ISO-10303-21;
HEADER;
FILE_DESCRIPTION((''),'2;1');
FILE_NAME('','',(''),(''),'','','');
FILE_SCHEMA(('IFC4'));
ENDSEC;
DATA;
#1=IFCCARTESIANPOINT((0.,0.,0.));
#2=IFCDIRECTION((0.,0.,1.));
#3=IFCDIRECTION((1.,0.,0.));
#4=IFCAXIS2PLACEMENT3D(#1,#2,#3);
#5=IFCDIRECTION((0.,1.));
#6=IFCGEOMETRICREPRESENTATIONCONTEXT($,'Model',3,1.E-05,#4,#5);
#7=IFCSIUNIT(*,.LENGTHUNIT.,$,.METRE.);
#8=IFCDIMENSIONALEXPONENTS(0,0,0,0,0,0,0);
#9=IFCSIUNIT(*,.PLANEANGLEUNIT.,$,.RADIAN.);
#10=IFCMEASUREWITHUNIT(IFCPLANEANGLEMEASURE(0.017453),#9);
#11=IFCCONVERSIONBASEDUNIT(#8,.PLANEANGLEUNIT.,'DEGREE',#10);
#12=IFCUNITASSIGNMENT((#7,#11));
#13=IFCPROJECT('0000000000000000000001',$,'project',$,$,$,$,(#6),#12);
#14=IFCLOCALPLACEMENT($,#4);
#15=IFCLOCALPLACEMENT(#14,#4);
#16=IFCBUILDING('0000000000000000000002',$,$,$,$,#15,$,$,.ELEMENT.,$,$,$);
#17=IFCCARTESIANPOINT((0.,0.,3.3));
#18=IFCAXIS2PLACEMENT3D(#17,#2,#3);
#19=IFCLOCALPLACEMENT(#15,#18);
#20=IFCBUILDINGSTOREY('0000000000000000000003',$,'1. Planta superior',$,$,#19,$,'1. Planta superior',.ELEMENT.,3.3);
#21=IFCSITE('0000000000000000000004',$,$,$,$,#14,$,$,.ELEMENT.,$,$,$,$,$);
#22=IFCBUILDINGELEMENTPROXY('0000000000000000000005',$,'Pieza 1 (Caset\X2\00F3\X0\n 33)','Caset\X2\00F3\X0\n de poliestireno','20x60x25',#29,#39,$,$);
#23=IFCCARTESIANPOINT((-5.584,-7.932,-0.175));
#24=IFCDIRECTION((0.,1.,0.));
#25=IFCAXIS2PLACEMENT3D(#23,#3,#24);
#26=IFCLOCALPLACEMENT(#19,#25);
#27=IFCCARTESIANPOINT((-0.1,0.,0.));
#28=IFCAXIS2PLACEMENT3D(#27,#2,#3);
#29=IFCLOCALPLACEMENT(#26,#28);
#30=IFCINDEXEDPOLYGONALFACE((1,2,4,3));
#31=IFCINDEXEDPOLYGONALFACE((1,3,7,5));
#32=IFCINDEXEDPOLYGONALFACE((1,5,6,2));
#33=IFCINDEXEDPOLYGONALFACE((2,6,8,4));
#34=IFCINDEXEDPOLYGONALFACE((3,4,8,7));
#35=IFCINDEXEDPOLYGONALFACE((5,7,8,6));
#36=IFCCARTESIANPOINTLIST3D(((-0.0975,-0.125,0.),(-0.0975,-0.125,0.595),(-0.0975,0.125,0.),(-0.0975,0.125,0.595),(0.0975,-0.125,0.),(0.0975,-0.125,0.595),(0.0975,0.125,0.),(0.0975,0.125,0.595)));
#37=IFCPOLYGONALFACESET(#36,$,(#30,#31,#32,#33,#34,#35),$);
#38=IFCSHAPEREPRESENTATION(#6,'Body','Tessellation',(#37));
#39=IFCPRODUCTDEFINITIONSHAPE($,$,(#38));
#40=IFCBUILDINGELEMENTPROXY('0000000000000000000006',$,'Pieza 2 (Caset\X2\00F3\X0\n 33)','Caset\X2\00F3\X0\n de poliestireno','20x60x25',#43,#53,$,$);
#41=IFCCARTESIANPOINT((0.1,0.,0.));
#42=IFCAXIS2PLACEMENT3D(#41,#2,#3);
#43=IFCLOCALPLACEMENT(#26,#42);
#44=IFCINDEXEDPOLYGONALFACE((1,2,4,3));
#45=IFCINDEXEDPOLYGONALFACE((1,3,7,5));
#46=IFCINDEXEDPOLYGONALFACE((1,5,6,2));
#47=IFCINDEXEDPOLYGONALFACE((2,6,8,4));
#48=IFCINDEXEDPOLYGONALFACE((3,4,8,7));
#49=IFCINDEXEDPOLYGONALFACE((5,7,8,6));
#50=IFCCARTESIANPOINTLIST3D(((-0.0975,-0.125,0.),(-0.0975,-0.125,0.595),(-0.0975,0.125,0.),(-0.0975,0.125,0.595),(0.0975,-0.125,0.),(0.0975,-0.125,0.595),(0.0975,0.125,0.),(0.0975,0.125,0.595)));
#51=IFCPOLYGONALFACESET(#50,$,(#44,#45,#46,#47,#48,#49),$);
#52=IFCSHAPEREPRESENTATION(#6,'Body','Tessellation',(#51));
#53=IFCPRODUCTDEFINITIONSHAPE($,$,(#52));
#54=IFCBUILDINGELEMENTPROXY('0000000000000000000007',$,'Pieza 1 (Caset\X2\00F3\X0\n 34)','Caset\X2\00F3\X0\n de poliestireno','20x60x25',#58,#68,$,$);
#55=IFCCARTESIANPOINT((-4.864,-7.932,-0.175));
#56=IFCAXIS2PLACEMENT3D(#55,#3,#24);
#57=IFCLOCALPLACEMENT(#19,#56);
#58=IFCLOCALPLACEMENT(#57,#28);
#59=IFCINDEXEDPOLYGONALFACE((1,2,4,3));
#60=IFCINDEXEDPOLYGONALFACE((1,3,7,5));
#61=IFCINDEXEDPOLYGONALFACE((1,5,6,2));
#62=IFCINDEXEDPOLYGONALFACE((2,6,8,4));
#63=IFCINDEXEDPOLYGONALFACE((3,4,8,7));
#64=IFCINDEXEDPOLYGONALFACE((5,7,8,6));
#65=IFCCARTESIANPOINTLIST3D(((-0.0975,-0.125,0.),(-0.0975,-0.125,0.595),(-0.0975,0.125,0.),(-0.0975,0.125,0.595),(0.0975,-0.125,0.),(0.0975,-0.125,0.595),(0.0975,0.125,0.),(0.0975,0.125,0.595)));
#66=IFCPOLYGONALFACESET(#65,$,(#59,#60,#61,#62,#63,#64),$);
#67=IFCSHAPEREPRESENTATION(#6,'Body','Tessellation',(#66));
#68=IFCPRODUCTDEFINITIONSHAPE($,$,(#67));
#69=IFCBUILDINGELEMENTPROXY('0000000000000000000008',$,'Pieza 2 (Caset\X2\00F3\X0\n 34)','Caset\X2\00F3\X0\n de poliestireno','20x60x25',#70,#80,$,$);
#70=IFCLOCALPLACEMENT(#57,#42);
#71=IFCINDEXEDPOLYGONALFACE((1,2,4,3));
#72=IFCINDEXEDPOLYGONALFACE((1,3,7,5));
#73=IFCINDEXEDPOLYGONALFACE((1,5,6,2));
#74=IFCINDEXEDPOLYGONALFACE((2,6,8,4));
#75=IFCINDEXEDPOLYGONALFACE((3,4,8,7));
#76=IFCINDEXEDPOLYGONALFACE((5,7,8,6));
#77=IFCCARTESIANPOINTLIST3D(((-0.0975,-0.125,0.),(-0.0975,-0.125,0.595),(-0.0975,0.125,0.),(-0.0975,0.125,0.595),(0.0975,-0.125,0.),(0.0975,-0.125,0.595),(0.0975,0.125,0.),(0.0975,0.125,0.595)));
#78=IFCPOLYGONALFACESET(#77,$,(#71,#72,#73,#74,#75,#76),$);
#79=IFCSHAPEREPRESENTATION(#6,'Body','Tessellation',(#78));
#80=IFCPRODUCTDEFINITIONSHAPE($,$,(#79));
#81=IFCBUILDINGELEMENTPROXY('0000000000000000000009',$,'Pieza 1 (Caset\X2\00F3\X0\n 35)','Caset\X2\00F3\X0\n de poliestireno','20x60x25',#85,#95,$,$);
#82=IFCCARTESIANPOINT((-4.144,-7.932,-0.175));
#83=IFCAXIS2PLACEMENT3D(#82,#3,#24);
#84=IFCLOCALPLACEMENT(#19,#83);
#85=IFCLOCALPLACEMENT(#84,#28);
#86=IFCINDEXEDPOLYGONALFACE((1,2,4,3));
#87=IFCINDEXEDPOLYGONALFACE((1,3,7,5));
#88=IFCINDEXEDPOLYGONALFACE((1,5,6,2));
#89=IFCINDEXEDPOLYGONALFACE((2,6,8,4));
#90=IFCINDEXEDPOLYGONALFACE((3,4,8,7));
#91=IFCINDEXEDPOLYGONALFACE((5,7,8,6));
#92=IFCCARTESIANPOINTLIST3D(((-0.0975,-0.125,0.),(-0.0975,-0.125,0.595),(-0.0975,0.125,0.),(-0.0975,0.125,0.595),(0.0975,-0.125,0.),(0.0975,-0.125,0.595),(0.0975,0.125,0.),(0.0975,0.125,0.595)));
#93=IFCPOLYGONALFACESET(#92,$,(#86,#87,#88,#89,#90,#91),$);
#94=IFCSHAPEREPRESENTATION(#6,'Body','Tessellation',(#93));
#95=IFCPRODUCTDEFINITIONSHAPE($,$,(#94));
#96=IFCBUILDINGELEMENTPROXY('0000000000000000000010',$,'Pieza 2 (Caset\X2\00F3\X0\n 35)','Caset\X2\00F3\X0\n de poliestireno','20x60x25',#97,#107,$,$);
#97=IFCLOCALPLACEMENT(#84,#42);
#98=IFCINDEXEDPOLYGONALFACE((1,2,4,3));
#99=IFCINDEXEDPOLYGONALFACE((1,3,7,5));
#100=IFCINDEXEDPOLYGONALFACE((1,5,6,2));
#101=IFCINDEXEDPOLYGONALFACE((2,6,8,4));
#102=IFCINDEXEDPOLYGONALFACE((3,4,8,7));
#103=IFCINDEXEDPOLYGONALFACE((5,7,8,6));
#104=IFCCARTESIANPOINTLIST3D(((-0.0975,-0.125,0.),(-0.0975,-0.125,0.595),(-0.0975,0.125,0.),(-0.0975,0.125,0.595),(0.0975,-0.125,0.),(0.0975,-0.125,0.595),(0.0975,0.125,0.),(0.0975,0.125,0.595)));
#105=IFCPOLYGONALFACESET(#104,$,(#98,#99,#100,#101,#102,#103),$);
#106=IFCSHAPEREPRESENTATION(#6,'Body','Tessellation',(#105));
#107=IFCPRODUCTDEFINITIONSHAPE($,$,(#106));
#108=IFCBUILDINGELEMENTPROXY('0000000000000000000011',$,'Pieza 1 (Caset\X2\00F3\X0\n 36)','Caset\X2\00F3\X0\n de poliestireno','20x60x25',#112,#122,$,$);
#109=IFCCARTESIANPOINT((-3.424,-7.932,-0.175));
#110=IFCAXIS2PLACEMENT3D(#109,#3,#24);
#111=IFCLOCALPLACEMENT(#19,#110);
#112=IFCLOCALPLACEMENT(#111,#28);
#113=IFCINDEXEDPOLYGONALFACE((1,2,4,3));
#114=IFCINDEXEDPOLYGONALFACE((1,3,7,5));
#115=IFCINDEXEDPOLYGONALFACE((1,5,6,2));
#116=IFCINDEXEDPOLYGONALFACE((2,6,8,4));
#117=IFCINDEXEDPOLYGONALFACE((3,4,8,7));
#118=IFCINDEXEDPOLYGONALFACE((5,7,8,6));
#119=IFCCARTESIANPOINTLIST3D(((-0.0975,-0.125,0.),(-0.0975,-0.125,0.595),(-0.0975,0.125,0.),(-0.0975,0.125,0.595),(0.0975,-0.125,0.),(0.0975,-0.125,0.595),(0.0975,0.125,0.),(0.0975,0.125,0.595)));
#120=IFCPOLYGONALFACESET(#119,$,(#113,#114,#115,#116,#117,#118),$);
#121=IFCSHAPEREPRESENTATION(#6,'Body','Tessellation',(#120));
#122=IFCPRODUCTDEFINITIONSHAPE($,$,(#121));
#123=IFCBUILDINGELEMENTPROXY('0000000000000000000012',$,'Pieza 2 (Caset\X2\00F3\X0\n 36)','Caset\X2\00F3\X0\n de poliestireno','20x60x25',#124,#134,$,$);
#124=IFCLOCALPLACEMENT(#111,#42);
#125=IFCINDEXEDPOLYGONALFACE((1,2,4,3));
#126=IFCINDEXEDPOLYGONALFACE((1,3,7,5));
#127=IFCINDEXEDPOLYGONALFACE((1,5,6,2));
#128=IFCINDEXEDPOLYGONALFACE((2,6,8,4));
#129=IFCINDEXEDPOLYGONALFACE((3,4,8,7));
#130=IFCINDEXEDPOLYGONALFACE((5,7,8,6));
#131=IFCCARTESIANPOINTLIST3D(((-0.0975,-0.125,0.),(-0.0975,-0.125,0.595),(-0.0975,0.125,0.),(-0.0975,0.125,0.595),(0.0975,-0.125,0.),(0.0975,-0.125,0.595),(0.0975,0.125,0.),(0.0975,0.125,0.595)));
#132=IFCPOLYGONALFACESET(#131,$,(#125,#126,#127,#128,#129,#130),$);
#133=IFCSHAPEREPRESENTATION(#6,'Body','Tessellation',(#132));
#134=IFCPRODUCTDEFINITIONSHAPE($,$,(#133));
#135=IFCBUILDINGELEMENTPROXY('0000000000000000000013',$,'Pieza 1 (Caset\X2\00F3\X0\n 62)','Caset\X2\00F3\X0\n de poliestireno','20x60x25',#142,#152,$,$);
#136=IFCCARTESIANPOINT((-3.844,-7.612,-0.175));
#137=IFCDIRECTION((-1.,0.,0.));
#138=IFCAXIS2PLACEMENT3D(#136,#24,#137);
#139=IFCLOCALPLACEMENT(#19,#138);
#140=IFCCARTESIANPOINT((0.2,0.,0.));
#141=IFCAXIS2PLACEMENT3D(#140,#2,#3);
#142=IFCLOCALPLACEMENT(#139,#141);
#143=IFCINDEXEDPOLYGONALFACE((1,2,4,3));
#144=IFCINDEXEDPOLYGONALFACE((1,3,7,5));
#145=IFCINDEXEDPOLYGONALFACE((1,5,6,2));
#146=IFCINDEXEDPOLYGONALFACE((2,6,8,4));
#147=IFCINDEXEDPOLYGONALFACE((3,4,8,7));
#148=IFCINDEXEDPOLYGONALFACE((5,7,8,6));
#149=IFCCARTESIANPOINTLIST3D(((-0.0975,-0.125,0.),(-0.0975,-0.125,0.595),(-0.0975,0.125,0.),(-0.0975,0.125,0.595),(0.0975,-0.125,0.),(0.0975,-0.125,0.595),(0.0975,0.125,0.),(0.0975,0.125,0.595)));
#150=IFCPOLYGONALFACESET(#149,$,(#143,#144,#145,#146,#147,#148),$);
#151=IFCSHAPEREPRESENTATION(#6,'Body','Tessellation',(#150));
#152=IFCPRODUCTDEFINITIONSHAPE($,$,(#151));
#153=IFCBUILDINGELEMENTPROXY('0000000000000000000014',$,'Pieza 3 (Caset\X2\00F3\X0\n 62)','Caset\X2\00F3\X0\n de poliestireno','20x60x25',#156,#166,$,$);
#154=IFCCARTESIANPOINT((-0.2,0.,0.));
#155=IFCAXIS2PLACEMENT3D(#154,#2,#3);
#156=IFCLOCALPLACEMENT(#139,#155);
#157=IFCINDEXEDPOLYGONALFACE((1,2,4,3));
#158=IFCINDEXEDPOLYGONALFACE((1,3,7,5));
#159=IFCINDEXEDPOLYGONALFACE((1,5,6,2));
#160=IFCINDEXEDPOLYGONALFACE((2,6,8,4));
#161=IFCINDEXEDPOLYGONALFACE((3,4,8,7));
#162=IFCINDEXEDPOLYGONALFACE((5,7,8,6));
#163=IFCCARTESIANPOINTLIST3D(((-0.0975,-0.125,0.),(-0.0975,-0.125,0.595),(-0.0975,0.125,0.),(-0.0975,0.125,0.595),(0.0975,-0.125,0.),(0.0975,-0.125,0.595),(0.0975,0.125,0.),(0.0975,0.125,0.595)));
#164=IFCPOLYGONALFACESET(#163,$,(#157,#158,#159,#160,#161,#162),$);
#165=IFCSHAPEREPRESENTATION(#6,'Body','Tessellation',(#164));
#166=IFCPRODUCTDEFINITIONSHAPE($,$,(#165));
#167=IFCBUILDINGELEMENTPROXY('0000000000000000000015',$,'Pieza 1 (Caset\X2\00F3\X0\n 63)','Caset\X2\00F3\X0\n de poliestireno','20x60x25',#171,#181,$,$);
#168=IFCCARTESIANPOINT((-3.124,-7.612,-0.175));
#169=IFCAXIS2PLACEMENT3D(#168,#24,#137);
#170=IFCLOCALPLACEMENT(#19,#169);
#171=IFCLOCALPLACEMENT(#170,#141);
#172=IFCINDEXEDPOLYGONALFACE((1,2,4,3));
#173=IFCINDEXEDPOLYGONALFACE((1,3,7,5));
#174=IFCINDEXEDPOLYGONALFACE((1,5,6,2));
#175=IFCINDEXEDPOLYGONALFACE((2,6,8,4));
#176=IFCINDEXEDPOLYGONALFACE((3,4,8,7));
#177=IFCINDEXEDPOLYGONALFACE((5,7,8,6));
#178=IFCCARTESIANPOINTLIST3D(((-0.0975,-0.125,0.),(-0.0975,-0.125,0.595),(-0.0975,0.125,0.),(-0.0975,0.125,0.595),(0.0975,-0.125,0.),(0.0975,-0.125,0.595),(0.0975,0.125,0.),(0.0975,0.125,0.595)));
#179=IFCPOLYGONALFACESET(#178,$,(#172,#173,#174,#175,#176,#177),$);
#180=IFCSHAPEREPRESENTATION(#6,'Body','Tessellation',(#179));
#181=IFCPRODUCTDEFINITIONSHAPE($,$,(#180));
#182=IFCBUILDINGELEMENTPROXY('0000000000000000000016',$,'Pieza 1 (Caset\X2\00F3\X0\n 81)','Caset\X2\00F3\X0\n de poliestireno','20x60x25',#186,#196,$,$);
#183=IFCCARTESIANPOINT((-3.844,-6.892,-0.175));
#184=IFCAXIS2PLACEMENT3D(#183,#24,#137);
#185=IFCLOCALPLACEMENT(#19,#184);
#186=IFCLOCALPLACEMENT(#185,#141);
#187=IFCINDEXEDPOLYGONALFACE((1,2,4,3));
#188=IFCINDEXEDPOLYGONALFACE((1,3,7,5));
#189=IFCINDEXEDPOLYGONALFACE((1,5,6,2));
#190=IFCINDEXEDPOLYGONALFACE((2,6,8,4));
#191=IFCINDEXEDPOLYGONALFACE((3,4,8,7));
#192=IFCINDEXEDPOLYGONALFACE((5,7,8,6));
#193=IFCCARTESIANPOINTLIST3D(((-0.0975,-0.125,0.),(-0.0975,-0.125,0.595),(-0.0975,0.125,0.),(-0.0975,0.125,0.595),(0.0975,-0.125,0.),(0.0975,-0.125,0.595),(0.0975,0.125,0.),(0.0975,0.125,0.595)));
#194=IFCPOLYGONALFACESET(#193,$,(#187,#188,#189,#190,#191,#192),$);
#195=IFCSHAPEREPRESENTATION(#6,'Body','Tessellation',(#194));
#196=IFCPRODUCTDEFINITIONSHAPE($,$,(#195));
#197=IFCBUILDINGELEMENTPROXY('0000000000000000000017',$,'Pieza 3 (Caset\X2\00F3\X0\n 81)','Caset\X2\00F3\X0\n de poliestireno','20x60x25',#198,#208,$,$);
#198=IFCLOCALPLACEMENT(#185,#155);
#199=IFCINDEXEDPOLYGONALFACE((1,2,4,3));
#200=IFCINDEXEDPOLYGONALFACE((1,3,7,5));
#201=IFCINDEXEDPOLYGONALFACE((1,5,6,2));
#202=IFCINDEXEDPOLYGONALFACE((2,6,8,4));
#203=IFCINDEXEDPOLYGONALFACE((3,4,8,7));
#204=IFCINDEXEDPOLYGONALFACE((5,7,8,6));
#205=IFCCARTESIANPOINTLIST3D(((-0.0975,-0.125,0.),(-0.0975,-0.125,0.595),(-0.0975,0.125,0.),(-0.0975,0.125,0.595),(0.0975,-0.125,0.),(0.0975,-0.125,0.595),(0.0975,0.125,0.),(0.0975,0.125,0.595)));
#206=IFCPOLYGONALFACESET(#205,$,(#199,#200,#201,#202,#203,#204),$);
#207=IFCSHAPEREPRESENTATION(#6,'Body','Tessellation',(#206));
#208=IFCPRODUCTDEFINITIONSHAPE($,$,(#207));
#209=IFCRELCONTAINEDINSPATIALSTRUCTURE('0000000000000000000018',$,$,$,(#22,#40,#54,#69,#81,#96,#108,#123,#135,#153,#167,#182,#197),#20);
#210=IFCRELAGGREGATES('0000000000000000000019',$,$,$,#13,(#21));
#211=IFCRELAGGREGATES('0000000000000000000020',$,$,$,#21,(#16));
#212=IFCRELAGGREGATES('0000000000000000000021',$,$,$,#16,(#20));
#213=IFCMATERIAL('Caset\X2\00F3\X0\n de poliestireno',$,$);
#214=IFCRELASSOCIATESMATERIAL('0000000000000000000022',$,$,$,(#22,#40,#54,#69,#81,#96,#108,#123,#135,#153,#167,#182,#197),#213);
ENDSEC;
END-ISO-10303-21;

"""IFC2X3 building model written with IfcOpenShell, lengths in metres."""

from ifc_helpers import new_model, entity, si_unit, converted_unit, direction, frame, origin_with_axes, origin_2d_with_axis, place, context, project, spatial, rectangle, extrude, source, transform, mapped, material, element, save


model = new_model("IFC2X3")

# Units and contexts
model_context = context("Model", 3, precision=1e-05, world=origin_with_axes(), true_north=direction((0.0, 1.0)))
ifc_project = project(units=[si_unit("LENGTHUNIT", "METRE"), converted_unit("PLANEANGLEUNIT", "DEGREE", entity("IfcPlaneAngleMeasure", 0.017453), si_unit("PLANEANGLEUNIT", "RADIAN"), dimensions=[0, 0, 0, 0, 0, 0, 0])], contexts=[model_context])

# Site, building, storey
site_placement = place(None, origin_with_axes())
site = spatial("IfcSite", under=ifc_project, at=site_placement, CompositionType="ELEMENT")
building_placement = place(site_placement, origin_with_axes())
building = spatial("IfcBuilding", under=site, at=building_placement, CompositionType="ELEMENT")
storey_placement = place(building_placement, frame((0.0, 0.0, 3.3), z_axis=(0.0, 0.0, 1.0), x_axis=(1.0, 0.0, 0.0)))
storey = spatial("IfcBuildingStorey", under=building, at=storey_placement, Name="1. Planta superior", LongName="1. Planta superior", CompositionType="ELEMENT", Elevation=3.3)

# Building element proxies
ifc_material_1 = material(Name="Casetón de poliestireno")
shared_shape = source(origin_with_axes(), model_context, "Body", "SweptSolid", [
    extrude(rectangle(XDim=0.195, YDim=0.25, at=origin_2d_with_axis()), origin_with_axes(), (0.0, 0.0, 1.0), 0.595),
])
placement_1 = place(storey_placement, frame((-5.584, -7.932, -0.175), z_axis=(1.0, 0.0, 0.0), x_axis=(0.0, 1.0, 0.0)))
for number, where, z_axis, x_axis, name in (
    (1, (-0.1, 0.0, 0.0), (0.0, 0.0, 1.0), (1.0, 0.0, 0.0), "Pieza 1 (Casetón 33)"),
    (2, (0.1, 0.0, 0.0), (0.0, 0.0, 1.0), (1.0, 0.0, 0.0), "Pieza 2 (Casetón 33)"),
):
    element("IfcBuildingElementProxy", number, at=place(placement_1, frame(where, z_axis=z_axis, x_axis=x_axis)), inside=storey, material=ifc_material_1, Name=name, Description="Casetón de poliestireno", ObjectType="20x60x25", context=model_context, shape_type="MappedRepresentation", body=[
        mapped(shared_shape, transform((0.0, 0.0, 0.0), x_axis=(1.0, 0.0, 0.0), y_axis=(0.0, 1.0, 0.0), z_axis=(0.0, 0.0, 1.0))),
    ])
placement_2 = place(storey_placement, frame((-4.864, -7.932, -0.175), z_axis=(1.0, 0.0, 0.0), x_axis=(0.0, 1.0, 0.0)))
for number, where, z_axis, x_axis, name in (
    (3, (-0.1, 0.0, 0.0), (0.0, 0.0, 1.0), (1.0, 0.0, 0.0), "Pieza 1 (Casetón 34)"),
    (4, (0.1, 0.0, 0.0), (0.0, 0.0, 1.0), (1.0, 0.0, 0.0), "Pieza 2 (Casetón 34)"),
):
    element("IfcBuildingElementProxy", number, at=place(placement_2, frame(where, z_axis=z_axis, x_axis=x_axis)), inside=storey, material=ifc_material_1, Name=name, Description="Casetón de poliestireno", ObjectType="20x60x25", context=model_context, shape_type="MappedRepresentation", body=[
        mapped(shared_shape, transform((0.0, 0.0, 0.0), x_axis=(1.0, 0.0, 0.0), y_axis=(0.0, 1.0, 0.0), z_axis=(0.0, 0.0, 1.0))),
    ])
placement_3 = place(storey_placement, frame((-4.144, -7.932, -0.175), z_axis=(1.0, 0.0, 0.0), x_axis=(0.0, 1.0, 0.0)))
for number, where, z_axis, x_axis, name in (
    (5, (-0.1, 0.0, 0.0), (0.0, 0.0, 1.0), (1.0, 0.0, 0.0), "Pieza 1 (Casetón 35)"),
    (6, (0.1, 0.0, 0.0), (0.0, 0.0, 1.0), (1.0, 0.0, 0.0), "Pieza 2 (Casetón 35)"),
):
    element("IfcBuildingElementProxy", number, at=place(placement_3, frame(where, z_axis=z_axis, x_axis=x_axis)), inside=storey, material=ifc_material_1, Name=name, Description="Casetón de poliestireno", ObjectType="20x60x25", context=model_context, shape_type="MappedRepresentation", body=[
        mapped(shared_shape, transform((0.0, 0.0, 0.0), x_axis=(1.0, 0.0, 0.0), y_axis=(0.0, 1.0, 0.0), z_axis=(0.0, 0.0, 1.0))),
    ])
placement_4 = place(storey_placement, frame((-3.424, -7.932, -0.175), z_axis=(1.0, 0.0, 0.0), x_axis=(0.0, 1.0, 0.0)))
for number, where, z_axis, x_axis, name in (
    (7, (-0.1, 0.0, 0.0), (0.0, 0.0, 1.0), (1.0, 0.0, 0.0), "Pieza 1 (Casetón 36)"),
    (8, (0.1, 0.0, 0.0), (0.0, 0.0, 1.0), (1.0, 0.0, 0.0), "Pieza 2 (Casetón 36)"),
):
    element("IfcBuildingElementProxy", number, at=place(placement_4, frame(where, z_axis=z_axis, x_axis=x_axis)), inside=storey, material=ifc_material_1, Name=name, Description="Casetón de poliestireno", ObjectType="20x60x25", context=model_context, shape_type="MappedRepresentation", body=[
        mapped(shared_shape, transform((0.0, 0.0, 0.0), x_axis=(1.0, 0.0, 0.0), y_axis=(0.0, 1.0, 0.0), z_axis=(0.0, 0.0, 1.0))),
    ])
placement_5 = place(storey_placement, frame((-3.844, -7.612, -0.175), z_axis=(0.0, 1.0, 0.0), x_axis=(-1.0, 0.0, 0.0)))
for number, where, z_axis, x_axis, name in (
    (9, (0.2, 0.0, 0.0), (0.0, 0.0, 1.0), (1.0, 0.0, 0.0), "Pieza 1 (Casetón 62)"),
    (10, (-0.2, 0.0, 0.0), (0.0, 0.0, 1.0), (1.0, 0.0, 0.0), "Pieza 3 (Casetón 62)"),
):
    element("IfcBuildingElementProxy", number, at=place(placement_5, frame(where, z_axis=z_axis, x_axis=x_axis)), inside=storey, material=ifc_material_1, Name=name, Description="Casetón de poliestireno", ObjectType="20x60x25", context=model_context, shape_type="MappedRepresentation", body=[
        mapped(shared_shape, transform((0.0, 0.0, 0.0), x_axis=(1.0, 0.0, 0.0), y_axis=(0.0, 1.0, 0.0), z_axis=(0.0, 0.0, 1.0))),
    ])
placement_6 = place(storey_placement, frame((-3.124, -7.612, -0.175), z_axis=(0.0, 1.0, 0.0), x_axis=(-1.0, 0.0, 0.0)))
for number, where, z_axis, x_axis, name in (
    (11, (0.2, 0.0, 0.0), (0.0, 0.0, 1.0), (1.0, 0.0, 0.0), "Pieza 1 (Casetón 63)"),
):
    element("IfcBuildingElementProxy", number, at=place(placement_6, frame(where, z_axis=z_axis, x_axis=x_axis)), inside=storey, material=ifc_material_1, Name=name, Description="Casetón de poliestireno", ObjectType="20x60x25", context=model_context, shape_type="MappedRepresentation", body=[
        mapped(shared_shape, transform((0.0, 0.0, 0.0), x_axis=(1.0, 0.0, 0.0), y_axis=(0.0, 1.0, 0.0), z_axis=(0.0, 0.0, 1.0))),
    ])
placement_7 = place(storey_placement, frame((-3.844, -6.892, -0.175), z_axis=(0.0, 1.0, 0.0), x_axis=(-1.0, 0.0, 0.0)))
for number, where, z_axis, x_axis, name in (
    (12, (0.2, 0.0, 0.0), (0.0, 0.0, 1.0), (1.0, 0.0, 0.0), "Pieza 1 (Casetón 81)"),
    (13, (-0.2, 0.0, 0.0), (0.0, 0.0, 1.0), (1.0, 0.0, 0.0), "Pieza 3 (Casetón 81)"),
):
    element("IfcBuildingElementProxy", number, at=place(placement_7, frame(where, z_axis=z_axis, x_axis=x_axis)), inside=storey, material=ifc_material_1, Name=name, Description="Casetón de poliestireno", ObjectType="20x60x25", context=model_context, shape_type="MappedRepresentation", body=[
        mapped(shared_shape, transform((0.0, 0.0, 0.0), x_axis=(1.0, 0.0, 0.0), y_axis=(0.0, 1.0, 0.0), z_axis=(0.0, 0.0, 1.0))),
    ])

save(model, "model.ifc")
